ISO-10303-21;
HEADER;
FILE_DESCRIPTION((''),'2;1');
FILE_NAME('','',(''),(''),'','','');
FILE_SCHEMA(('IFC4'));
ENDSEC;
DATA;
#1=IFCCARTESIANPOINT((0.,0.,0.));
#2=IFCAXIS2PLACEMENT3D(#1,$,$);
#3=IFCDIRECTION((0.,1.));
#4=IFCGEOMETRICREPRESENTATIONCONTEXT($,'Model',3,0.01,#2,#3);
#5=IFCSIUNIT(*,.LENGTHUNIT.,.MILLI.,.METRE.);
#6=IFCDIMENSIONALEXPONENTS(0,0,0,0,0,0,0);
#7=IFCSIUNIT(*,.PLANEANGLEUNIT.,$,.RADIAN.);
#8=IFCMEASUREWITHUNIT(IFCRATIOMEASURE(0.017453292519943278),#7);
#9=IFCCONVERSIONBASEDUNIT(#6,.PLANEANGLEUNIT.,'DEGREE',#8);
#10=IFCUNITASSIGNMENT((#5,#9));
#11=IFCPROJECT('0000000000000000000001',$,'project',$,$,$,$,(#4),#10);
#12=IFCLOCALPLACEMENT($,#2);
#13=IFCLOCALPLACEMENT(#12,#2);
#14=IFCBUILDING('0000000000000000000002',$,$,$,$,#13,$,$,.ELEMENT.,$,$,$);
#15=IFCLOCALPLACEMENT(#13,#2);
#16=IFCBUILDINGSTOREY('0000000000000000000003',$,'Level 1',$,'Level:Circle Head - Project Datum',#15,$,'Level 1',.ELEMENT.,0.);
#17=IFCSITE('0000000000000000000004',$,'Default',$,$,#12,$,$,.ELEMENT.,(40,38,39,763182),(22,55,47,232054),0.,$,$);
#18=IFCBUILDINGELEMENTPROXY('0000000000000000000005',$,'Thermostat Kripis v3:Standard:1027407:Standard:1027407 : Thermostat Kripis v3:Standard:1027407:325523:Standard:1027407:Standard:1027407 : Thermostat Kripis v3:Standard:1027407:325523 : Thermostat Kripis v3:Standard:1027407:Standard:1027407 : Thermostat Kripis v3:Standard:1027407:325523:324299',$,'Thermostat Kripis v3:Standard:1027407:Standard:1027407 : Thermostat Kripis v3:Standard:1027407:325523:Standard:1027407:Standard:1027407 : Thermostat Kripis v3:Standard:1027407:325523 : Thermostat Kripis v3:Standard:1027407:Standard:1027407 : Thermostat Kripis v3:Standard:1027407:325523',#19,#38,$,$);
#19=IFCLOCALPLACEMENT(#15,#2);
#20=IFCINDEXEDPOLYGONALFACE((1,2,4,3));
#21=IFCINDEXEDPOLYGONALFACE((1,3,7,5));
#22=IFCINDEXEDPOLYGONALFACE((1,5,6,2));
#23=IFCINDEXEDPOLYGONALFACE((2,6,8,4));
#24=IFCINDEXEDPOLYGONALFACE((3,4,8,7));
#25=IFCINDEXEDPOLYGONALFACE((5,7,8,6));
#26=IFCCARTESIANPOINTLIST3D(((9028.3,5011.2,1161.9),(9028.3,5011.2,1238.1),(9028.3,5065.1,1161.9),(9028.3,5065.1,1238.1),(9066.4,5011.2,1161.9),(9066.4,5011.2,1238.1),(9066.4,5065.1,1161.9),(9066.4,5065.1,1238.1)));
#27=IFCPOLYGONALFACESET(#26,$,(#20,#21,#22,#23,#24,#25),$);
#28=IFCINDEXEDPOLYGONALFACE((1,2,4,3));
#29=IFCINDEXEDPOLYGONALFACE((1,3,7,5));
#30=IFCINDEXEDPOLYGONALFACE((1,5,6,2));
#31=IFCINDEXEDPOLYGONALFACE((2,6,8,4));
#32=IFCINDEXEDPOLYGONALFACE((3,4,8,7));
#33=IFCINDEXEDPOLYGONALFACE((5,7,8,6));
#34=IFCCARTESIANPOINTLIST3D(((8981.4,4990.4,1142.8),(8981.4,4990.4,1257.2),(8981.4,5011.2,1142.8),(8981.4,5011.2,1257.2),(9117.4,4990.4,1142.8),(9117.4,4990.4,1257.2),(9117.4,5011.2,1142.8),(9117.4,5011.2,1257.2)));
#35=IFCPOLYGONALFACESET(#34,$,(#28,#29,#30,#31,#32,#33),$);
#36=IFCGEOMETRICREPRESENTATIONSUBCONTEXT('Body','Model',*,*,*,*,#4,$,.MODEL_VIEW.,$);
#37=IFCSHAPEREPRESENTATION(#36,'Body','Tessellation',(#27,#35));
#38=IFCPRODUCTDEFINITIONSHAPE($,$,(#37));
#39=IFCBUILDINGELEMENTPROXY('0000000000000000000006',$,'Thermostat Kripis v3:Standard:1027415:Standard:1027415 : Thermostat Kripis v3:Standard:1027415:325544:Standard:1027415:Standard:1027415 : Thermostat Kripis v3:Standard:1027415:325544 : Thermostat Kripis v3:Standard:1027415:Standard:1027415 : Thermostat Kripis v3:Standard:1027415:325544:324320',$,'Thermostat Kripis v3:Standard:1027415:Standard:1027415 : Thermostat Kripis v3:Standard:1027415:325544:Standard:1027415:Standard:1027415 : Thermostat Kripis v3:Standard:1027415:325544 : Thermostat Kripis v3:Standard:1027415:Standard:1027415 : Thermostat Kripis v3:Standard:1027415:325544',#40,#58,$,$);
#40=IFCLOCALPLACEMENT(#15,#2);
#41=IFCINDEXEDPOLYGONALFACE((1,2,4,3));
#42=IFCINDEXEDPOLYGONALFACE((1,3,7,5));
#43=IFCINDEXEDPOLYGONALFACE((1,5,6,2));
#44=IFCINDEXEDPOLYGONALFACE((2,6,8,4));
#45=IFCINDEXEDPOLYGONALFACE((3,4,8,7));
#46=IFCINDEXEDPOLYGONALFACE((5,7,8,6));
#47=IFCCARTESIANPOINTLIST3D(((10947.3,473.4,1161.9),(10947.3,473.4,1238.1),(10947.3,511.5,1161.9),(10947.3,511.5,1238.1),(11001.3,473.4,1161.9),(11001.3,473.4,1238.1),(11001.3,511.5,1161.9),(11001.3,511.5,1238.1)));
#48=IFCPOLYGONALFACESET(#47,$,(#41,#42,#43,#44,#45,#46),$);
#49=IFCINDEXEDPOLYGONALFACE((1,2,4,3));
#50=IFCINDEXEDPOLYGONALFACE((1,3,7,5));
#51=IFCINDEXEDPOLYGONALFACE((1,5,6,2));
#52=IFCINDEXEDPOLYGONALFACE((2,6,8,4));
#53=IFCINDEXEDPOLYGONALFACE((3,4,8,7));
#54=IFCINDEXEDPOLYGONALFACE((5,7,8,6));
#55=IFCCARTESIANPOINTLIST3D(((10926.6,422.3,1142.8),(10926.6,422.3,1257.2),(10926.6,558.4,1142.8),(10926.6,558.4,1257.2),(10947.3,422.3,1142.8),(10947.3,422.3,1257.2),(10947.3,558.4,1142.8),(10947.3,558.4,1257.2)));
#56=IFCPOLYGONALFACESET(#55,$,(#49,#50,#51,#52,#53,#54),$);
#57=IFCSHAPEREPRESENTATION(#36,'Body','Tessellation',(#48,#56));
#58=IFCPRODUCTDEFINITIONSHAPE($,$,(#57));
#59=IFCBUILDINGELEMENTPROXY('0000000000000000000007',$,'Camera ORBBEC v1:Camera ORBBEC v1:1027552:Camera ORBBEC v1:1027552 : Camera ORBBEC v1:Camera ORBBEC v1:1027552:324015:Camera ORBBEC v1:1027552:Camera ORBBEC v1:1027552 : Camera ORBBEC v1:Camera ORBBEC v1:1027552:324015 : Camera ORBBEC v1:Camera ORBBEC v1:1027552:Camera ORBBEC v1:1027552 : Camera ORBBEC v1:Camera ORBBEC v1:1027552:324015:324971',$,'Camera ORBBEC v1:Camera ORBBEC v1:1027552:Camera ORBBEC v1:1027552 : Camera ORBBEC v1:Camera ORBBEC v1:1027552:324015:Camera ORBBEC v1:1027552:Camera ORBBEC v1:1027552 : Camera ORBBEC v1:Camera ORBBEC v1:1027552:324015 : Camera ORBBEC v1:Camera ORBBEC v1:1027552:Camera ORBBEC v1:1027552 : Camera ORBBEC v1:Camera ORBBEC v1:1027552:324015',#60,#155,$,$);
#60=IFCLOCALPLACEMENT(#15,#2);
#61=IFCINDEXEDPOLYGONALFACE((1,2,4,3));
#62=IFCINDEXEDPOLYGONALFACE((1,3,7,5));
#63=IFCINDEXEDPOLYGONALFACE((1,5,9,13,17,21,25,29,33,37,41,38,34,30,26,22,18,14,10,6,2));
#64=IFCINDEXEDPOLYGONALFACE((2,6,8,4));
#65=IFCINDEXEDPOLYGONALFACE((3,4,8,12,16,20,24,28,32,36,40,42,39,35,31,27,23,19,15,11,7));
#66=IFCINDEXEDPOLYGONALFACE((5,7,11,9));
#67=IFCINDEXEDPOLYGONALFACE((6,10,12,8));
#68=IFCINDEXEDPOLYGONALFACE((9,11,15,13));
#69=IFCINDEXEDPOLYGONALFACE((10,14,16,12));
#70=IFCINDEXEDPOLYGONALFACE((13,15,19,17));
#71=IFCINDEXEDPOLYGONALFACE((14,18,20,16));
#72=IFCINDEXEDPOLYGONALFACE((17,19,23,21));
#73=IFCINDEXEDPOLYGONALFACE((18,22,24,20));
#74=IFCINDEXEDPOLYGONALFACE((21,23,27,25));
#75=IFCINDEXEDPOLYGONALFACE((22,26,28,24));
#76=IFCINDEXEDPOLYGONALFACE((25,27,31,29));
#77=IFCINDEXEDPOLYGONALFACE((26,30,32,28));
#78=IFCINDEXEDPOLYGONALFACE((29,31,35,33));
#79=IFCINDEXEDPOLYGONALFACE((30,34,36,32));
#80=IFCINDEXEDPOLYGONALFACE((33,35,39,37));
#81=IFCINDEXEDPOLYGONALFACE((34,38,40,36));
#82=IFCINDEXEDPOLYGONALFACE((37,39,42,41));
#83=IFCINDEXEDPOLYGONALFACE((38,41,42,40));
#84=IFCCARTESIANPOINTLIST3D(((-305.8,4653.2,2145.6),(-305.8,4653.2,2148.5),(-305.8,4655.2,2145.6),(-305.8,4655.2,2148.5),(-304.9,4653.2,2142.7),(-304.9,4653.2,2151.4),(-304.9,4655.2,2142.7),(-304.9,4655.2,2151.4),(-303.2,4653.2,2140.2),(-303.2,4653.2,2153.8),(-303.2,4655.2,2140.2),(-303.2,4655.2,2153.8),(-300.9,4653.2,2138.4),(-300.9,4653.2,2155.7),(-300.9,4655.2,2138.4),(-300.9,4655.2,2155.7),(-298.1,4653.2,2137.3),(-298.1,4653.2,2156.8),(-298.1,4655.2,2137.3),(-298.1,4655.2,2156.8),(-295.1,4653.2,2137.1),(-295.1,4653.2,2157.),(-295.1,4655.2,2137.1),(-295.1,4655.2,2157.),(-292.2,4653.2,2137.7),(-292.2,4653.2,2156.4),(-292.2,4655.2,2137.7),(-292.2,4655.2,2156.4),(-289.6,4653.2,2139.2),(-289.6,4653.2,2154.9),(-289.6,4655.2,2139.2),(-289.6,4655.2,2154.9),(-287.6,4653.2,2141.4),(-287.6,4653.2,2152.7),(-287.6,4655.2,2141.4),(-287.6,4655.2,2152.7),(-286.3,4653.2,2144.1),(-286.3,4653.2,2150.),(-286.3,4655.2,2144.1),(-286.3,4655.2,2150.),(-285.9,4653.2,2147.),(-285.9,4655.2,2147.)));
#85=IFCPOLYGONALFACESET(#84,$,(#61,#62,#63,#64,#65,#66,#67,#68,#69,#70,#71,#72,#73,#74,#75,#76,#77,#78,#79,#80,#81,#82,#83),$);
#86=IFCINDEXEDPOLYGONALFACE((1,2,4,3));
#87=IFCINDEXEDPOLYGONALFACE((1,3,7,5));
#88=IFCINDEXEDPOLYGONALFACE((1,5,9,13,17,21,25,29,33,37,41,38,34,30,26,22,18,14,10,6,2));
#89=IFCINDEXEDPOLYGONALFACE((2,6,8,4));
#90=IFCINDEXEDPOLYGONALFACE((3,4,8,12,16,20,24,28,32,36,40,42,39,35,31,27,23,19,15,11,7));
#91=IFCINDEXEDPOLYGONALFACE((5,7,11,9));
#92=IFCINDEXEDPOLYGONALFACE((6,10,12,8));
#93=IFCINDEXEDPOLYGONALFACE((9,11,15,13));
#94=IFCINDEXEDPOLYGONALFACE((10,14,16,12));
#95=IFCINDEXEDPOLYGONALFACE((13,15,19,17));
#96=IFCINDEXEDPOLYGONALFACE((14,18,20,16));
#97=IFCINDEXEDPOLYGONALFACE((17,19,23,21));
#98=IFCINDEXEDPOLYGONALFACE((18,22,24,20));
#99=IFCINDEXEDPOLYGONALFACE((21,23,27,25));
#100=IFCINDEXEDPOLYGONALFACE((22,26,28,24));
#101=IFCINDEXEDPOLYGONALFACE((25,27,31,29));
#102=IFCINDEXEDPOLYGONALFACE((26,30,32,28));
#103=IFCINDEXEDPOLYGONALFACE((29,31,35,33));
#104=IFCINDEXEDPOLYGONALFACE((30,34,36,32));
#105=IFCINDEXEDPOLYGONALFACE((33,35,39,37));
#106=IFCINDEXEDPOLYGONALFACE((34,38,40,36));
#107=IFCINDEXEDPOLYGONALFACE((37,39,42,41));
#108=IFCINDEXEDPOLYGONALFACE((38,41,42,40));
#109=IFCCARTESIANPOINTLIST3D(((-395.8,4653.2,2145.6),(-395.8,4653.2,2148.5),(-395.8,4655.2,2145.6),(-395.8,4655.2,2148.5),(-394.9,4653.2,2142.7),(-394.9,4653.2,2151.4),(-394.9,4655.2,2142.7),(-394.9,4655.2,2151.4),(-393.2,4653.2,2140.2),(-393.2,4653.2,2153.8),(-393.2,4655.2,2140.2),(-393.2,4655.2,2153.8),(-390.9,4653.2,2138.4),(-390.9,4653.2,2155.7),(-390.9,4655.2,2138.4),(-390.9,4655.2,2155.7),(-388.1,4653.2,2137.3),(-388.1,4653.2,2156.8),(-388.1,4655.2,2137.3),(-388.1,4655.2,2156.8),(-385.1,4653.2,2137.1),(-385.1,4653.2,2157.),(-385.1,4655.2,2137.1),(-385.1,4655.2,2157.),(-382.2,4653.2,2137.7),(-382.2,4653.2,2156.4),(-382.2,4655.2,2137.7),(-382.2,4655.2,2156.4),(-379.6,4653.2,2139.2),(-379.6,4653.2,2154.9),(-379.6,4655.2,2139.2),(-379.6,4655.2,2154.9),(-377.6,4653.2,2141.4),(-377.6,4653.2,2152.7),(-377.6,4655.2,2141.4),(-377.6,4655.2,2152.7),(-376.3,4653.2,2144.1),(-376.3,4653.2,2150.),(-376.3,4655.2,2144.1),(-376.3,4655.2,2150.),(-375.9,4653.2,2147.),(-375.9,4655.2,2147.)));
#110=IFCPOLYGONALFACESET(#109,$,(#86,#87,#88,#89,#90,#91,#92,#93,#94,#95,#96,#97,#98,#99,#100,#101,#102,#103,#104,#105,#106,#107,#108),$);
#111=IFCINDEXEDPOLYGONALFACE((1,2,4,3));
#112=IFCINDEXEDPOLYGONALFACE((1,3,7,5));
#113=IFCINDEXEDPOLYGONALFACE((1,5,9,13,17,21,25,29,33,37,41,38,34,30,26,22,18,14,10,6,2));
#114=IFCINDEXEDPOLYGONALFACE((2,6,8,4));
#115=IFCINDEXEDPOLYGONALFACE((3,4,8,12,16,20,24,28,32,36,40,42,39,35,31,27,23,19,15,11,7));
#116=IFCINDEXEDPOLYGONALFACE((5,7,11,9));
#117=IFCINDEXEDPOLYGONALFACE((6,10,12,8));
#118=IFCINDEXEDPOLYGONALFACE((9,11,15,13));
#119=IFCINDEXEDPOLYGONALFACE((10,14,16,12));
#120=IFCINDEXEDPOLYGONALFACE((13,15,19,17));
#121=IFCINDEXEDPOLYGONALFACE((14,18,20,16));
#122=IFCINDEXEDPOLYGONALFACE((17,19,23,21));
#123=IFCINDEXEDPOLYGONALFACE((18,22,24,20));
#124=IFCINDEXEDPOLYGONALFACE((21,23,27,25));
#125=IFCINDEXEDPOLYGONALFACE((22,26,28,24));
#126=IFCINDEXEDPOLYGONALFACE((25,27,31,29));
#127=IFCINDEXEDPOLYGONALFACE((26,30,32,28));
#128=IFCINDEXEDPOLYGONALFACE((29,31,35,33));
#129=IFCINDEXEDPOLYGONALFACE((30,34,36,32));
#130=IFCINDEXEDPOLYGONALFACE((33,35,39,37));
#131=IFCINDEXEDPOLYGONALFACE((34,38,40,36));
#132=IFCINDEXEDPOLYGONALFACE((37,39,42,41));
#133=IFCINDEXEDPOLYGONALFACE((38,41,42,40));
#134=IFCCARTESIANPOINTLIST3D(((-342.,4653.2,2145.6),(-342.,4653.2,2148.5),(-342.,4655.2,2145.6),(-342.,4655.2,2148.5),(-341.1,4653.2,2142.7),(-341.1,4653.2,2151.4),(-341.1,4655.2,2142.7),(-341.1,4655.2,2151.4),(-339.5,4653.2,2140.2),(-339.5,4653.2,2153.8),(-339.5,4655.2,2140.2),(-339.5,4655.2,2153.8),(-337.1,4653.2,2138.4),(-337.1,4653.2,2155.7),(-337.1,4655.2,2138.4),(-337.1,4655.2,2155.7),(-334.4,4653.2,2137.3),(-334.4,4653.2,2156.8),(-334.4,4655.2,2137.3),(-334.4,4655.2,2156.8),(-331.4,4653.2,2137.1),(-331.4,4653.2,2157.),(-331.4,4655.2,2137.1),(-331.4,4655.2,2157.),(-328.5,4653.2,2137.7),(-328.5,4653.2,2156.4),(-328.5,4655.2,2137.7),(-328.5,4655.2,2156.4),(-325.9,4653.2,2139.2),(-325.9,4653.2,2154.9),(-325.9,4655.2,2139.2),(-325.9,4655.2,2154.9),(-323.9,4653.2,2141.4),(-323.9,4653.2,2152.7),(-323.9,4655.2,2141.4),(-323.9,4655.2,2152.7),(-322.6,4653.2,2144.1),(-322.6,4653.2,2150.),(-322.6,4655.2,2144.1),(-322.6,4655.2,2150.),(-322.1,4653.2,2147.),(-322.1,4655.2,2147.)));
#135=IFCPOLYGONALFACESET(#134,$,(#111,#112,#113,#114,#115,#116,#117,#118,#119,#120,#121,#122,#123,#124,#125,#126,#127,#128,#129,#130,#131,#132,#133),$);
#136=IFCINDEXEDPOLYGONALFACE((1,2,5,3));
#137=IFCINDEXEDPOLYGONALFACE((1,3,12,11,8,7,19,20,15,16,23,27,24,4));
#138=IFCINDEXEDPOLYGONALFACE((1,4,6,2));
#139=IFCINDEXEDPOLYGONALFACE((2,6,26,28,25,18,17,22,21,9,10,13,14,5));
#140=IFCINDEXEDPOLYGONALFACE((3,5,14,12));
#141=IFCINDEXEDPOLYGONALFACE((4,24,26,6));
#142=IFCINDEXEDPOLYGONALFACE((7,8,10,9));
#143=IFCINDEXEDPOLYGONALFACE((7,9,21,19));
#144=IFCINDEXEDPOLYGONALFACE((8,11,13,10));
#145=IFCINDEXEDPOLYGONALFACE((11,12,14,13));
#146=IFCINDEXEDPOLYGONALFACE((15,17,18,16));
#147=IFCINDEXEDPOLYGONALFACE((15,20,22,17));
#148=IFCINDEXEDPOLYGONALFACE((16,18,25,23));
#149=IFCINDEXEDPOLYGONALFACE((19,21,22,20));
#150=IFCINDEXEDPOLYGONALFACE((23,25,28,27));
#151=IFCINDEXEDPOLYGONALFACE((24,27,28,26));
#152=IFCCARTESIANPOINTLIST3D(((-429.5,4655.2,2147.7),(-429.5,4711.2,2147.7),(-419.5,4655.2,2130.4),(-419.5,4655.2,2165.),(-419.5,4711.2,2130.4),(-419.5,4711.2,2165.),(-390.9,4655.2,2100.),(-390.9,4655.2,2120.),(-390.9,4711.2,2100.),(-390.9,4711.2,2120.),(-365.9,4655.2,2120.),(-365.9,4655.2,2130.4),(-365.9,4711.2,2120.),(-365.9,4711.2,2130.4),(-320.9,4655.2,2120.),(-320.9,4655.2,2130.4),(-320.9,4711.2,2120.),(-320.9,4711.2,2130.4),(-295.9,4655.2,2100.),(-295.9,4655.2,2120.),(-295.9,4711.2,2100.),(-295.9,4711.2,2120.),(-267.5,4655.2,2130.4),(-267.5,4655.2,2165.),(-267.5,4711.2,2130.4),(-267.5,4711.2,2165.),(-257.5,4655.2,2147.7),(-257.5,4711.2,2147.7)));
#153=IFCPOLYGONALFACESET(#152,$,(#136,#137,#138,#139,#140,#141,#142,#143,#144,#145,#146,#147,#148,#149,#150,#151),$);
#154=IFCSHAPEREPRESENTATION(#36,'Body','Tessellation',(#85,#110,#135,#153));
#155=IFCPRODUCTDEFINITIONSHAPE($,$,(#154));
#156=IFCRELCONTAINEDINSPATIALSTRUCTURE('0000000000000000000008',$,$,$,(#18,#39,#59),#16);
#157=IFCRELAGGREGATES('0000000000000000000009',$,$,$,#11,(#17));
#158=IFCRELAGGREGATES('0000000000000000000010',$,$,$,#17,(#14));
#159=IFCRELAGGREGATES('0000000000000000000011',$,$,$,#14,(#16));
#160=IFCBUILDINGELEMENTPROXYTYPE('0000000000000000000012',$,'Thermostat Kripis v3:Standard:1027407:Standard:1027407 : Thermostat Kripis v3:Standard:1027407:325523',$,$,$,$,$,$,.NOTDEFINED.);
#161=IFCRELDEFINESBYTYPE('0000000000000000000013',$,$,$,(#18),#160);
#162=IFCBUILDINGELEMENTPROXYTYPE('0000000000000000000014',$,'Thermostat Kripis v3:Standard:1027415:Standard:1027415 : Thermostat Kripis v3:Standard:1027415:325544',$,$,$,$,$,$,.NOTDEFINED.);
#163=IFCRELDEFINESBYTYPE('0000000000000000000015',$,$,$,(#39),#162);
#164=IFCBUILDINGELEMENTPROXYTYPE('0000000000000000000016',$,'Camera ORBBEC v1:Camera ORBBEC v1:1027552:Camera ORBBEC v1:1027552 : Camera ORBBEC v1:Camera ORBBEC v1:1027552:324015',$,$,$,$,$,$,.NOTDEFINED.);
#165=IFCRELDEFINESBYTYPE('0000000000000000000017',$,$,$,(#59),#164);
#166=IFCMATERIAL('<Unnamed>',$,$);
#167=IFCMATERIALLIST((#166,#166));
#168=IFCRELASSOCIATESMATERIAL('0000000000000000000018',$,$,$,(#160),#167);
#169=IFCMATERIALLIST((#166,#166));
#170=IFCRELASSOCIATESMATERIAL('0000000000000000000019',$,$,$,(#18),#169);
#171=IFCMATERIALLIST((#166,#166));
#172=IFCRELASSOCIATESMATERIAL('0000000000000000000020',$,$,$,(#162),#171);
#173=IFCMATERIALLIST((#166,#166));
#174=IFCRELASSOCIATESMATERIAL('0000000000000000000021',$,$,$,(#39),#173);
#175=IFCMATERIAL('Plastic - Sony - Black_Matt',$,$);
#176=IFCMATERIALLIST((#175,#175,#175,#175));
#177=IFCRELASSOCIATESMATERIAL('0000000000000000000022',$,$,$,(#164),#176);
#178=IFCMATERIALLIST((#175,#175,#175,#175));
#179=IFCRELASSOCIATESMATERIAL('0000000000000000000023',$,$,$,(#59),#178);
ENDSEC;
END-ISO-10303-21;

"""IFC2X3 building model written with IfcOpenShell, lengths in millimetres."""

from ifc_helpers import new_model, entity, si_unit, converted_unit, direction, frame, frame_2d, origin, origin_2d_with_axis, place, context, subcontext, project, spatial, polyline, rectangle, circle, outline, extrude, source, transform, mapped, material, material_list, type_object, type_shapes, element, save


model = new_model("IFC2X3")

# Units and contexts
model_context = context("Model", 3, precision=0.01, world=origin(), true_north=direction((0.0, 1.0)))
body_context = subcontext(model_context, "Body", "Model", "MODEL_VIEW")
ifc_project = project(units=[si_unit("LENGTHUNIT", "METRE", prefix="MILLI"), converted_unit("PLANEANGLEUNIT", "DEGREE", entity("IfcRatioMeasure", 0.017453292519943278), si_unit("PLANEANGLEUNIT", "RADIAN"), dimensions=[0, 0, 0, 0, 0, 0, 0])], contexts=[model_context])

# Site, building, storey
site_placement = place(None, origin())
site = spatial("IfcSite", under=ifc_project, at=site_placement, Name="Default", CompositionType="ELEMENT", RefLatitude=(40, 38, 39, 763182), RefLongitude=(22, 55, 47, 232054), RefElevation=0.0)
building_placement = place(site_placement, origin())
building = spatial("IfcBuilding", under=site, at=building_placement, CompositionType="ELEMENT")
storey_placement = place(building_placement, origin())
storey = spatial("IfcBuildingStorey", under=building, at=storey_placement, Name="Level 1", ObjectType="Level:Circle Head - Project Datum", LongName="Level 1", CompositionType="ELEMENT", Elevation=0.0)

# Building element proxies
ifc_material_1 = material(Name="<Unnamed>")
ifc_material_list_1 = material_list([ifc_material_1, ifc_material_1])
ifc_material_list_2 = material_list([ifc_material_1, ifc_material_1])
building_element_proxy_type_1 = type_object("IfcBuildingElementProxyType", Name="Thermostat Kripis v3:Standard:1027407:Standard:1027407 : Thermostat Kripis v3:Standard:1027407:325523", PredefinedType="NOTDEFINED", material=ifc_material_list_2)
shared_shape_1 = source(origin(), body_context, "Body", "SweptSolid", [
    extrude(rectangle(XDim=38.1, YDim=54.0, at=origin_2d_with_axis()), frame((9047.3, 5038.1, 1161.9), z_axis=(0.0, 0.0, 1.0), x_axis=(-1.0, 0.0, 0.0)), (0.0, 0.0, 1.0), 76.2),
    extrude(rectangle(XDim=136.0, YDim=20.7, at=origin_2d_with_axis()), frame((9049.4, 5000.8, 1142.8), z_axis=(0.0, 0.0, 1.0), x_axis=(-1.0, 0.0, 0.0)), (0.0, 0.0, 1.0), 114.3),
])
type_shapes(building_element_proxy_type_1, [shared_shape_1])
proxy_1_placement = place(storey_placement, origin())
element("IfcBuildingElementProxy", 1, at=proxy_1_placement, inside=storey, type_object=building_element_proxy_type_1, material=ifc_material_list_1, Name="Thermostat Kripis v3:Standard:1027407:Standard:1027407 : Thermostat Kripis v3:Standard:1027407:325523:Standard:1027407:Standard:1027407 : Thermostat Kripis v3:Standard:1027407:325523 : Thermostat Kripis v3:Standard:1027407:Standard:1027407 : Thermostat Kripis v3:Standard:1027407:325523:324299", ObjectType="Thermostat Kripis v3:Standard:1027407:Standard:1027407 : Thermostat Kripis v3:Standard:1027407:325523:Standard:1027407:Standard:1027407 : Thermostat Kripis v3:Standard:1027407:325523 : Thermostat Kripis v3:Standard:1027407:Standard:1027407 : Thermostat Kripis v3:Standard:1027407:325523", context=body_context, shape_type="MappedRepresentation", body=[
    mapped(shared_shape_1, transform((0.0, 0.0, 0.0), scale=1.0)),
])
ifc_material_list_3 = material_list([ifc_material_1, ifc_material_1])
ifc_material_list_4 = material_list([ifc_material_1, ifc_material_1])
building_element_proxy_type_2 = type_object("IfcBuildingElementProxyType", Name="Thermostat Kripis v3:Standard:1027415:Standard:1027415 : Thermostat Kripis v3:Standard:1027415:325544", PredefinedType="NOTDEFINED", material=ifc_material_list_4)
shared_shape_2 = source(origin(), body_context, "Body", "SweptSolid", [
    extrude(rectangle(XDim=38.1, YDim=54.0, at=frame_2d((0.0, 0.0), x_axis=(1.0, 0.0))), frame((10974.3, 492.4, 1161.9), z_axis=(0.0, 0.0, 1.0), x_axis=(0.0, 1.0, 0.0)), (0.0, 0.0, 1.0), 76.2),
    extrude(rectangle(XDim=136.0, YDim=20.7, at=origin_2d_with_axis()), frame((10937.0, 490.4, 1142.8), z_axis=(0.0, 0.0, 1.0), x_axis=(0.0, 1.0, 0.0)), (0.0, 0.0, 1.0), 114.3),
])
type_shapes(building_element_proxy_type_2, [shared_shape_2])
proxy_2_placement = place(storey_placement, origin())
element("IfcBuildingElementProxy", 2, at=proxy_2_placement, inside=storey, type_object=building_element_proxy_type_2, material=ifc_material_list_3, Name="Thermostat Kripis v3:Standard:1027415:Standard:1027415 : Thermostat Kripis v3:Standard:1027415:325544:Standard:1027415:Standard:1027415 : Thermostat Kripis v3:Standard:1027415:325544 : Thermostat Kripis v3:Standard:1027415:Standard:1027415 : Thermostat Kripis v3:Standard:1027415:325544:324320", ObjectType="Thermostat Kripis v3:Standard:1027415:Standard:1027415 : Thermostat Kripis v3:Standard:1027415:325544:Standard:1027415:Standard:1027415 : Thermostat Kripis v3:Standard:1027415:325544 : Thermostat Kripis v3:Standard:1027415:Standard:1027415 : Thermostat Kripis v3:Standard:1027415:325544", context=body_context, shape_type="MappedRepresentation", body=[
    mapped(shared_shape_2, transform((0.0, 0.0, 0.0), scale=1.0)),
])
ifc_material_2 = material(Name="Plastic - Sony - Black_Matt")
ifc_material_list_5 = material_list([ifc_material_2, ifc_material_2, ifc_material_2, ifc_material_2])
ifc_material_list_6 = material_list([ifc_material_2, ifc_material_2, ifc_material_2, ifc_material_2])
building_element_proxy_type_3 = type_object("IfcBuildingElementProxyType", Name="Camera ORBBEC v1:Camera ORBBEC v1:1027552:Camera ORBBEC v1:1027552 : Camera ORBBEC v1:Camera ORBBEC v1:1027552:324015", PredefinedType="NOTDEFINED", material=ifc_material_list_6)
shared_shape_3 = source(origin(), body_context, "Body", "SweptSolid", [
    extrude(circle(Radius=10.0, at=origin_2d_with_axis()), frame((-295.9, 4653.2, 2147.0), z_axis=(0.0, 1.0, 0.0), x_axis=(1.0, 0.0, 0.0)), (0.0, 0.0, 1.0), 2.0),
    extrude(circle(Radius=10.0, at=origin_2d_with_axis()), frame((-385.9, 4653.2, 2147.0), z_axis=(0.0, 1.0, 0.0), x_axis=(1.0, 0.0, 0.0)), (0.0, 0.0, 1.0), 2.0),
    extrude(circle(Radius=10.0, at=origin_2d_with_axis()), frame((-332.1, 4653.2, 2147.0), z_axis=(0.0, 1.0, 0.0), x_axis=(1.0, 0.0, 0.0)), (0.0, 0.0, 1.0), 2.0),
    extrude(outline(polyline([(8.1, -83.0), (28.1, -83.0), (38.1, -65.7), (11.4, -19.5), (20.3, -14.3), (32.8, -35.9), (50.2, -25.9), (2.7, 56.3), (-14.7, 46.3), (-2.2, 24.7), (-11.1, 19.5), (-37.9, 65.9), (-57.9, 65.9), (-67.9, 48.6), (8.1, -83.0)])), frame((-343.4, 4655.2, 2130.5), z_axis=(0.0, 1.0, 0.0), x_axis=(0.5, 0.0, -0.866025)), (0.0, 0.0, 1.0), 56.0),
])
type_shapes(building_element_proxy_type_3, [shared_shape_3])
proxy_3_placement = place(storey_placement, origin())
element("IfcBuildingElementProxy", 3, at=proxy_3_placement, inside=storey, type_object=building_element_proxy_type_3, material=ifc_material_list_5, Name="Camera ORBBEC v1:Camera ORBBEC v1:1027552:Camera ORBBEC v1:1027552 : Camera ORBBEC v1:Camera ORBBEC v1:1027552:324015:Camera ORBBEC v1:1027552:Camera ORBBEC v1:1027552 : Camera ORBBEC v1:Camera ORBBEC v1:1027552:324015 : Camera ORBBEC v1:Camera ORBBEC v1:1027552:Camera ORBBEC v1:1027552 : Camera ORBBEC v1:Camera ORBBEC v1:1027552:324015:324971", ObjectType="Camera ORBBEC v1:Camera ORBBEC v1:1027552:Camera ORBBEC v1:1027552 : Camera ORBBEC v1:Camera ORBBEC v1:1027552:324015:Camera ORBBEC v1:1027552:Camera ORBBEC v1:1027552 : Camera ORBBEC v1:Camera ORBBEC v1:1027552:324015 : Camera ORBBEC v1:Camera ORBBEC v1:1027552:Camera ORBBEC v1:1027552 : Camera ORBBEC v1:Camera ORBBEC v1:1027552:324015", context=body_context, shape_type="MappedRepresentation", body=[
    mapped(shared_shape_3, transform((0.0, 0.0, 0.0), scale=1.0)),
])

save(model, "model.ifc")
